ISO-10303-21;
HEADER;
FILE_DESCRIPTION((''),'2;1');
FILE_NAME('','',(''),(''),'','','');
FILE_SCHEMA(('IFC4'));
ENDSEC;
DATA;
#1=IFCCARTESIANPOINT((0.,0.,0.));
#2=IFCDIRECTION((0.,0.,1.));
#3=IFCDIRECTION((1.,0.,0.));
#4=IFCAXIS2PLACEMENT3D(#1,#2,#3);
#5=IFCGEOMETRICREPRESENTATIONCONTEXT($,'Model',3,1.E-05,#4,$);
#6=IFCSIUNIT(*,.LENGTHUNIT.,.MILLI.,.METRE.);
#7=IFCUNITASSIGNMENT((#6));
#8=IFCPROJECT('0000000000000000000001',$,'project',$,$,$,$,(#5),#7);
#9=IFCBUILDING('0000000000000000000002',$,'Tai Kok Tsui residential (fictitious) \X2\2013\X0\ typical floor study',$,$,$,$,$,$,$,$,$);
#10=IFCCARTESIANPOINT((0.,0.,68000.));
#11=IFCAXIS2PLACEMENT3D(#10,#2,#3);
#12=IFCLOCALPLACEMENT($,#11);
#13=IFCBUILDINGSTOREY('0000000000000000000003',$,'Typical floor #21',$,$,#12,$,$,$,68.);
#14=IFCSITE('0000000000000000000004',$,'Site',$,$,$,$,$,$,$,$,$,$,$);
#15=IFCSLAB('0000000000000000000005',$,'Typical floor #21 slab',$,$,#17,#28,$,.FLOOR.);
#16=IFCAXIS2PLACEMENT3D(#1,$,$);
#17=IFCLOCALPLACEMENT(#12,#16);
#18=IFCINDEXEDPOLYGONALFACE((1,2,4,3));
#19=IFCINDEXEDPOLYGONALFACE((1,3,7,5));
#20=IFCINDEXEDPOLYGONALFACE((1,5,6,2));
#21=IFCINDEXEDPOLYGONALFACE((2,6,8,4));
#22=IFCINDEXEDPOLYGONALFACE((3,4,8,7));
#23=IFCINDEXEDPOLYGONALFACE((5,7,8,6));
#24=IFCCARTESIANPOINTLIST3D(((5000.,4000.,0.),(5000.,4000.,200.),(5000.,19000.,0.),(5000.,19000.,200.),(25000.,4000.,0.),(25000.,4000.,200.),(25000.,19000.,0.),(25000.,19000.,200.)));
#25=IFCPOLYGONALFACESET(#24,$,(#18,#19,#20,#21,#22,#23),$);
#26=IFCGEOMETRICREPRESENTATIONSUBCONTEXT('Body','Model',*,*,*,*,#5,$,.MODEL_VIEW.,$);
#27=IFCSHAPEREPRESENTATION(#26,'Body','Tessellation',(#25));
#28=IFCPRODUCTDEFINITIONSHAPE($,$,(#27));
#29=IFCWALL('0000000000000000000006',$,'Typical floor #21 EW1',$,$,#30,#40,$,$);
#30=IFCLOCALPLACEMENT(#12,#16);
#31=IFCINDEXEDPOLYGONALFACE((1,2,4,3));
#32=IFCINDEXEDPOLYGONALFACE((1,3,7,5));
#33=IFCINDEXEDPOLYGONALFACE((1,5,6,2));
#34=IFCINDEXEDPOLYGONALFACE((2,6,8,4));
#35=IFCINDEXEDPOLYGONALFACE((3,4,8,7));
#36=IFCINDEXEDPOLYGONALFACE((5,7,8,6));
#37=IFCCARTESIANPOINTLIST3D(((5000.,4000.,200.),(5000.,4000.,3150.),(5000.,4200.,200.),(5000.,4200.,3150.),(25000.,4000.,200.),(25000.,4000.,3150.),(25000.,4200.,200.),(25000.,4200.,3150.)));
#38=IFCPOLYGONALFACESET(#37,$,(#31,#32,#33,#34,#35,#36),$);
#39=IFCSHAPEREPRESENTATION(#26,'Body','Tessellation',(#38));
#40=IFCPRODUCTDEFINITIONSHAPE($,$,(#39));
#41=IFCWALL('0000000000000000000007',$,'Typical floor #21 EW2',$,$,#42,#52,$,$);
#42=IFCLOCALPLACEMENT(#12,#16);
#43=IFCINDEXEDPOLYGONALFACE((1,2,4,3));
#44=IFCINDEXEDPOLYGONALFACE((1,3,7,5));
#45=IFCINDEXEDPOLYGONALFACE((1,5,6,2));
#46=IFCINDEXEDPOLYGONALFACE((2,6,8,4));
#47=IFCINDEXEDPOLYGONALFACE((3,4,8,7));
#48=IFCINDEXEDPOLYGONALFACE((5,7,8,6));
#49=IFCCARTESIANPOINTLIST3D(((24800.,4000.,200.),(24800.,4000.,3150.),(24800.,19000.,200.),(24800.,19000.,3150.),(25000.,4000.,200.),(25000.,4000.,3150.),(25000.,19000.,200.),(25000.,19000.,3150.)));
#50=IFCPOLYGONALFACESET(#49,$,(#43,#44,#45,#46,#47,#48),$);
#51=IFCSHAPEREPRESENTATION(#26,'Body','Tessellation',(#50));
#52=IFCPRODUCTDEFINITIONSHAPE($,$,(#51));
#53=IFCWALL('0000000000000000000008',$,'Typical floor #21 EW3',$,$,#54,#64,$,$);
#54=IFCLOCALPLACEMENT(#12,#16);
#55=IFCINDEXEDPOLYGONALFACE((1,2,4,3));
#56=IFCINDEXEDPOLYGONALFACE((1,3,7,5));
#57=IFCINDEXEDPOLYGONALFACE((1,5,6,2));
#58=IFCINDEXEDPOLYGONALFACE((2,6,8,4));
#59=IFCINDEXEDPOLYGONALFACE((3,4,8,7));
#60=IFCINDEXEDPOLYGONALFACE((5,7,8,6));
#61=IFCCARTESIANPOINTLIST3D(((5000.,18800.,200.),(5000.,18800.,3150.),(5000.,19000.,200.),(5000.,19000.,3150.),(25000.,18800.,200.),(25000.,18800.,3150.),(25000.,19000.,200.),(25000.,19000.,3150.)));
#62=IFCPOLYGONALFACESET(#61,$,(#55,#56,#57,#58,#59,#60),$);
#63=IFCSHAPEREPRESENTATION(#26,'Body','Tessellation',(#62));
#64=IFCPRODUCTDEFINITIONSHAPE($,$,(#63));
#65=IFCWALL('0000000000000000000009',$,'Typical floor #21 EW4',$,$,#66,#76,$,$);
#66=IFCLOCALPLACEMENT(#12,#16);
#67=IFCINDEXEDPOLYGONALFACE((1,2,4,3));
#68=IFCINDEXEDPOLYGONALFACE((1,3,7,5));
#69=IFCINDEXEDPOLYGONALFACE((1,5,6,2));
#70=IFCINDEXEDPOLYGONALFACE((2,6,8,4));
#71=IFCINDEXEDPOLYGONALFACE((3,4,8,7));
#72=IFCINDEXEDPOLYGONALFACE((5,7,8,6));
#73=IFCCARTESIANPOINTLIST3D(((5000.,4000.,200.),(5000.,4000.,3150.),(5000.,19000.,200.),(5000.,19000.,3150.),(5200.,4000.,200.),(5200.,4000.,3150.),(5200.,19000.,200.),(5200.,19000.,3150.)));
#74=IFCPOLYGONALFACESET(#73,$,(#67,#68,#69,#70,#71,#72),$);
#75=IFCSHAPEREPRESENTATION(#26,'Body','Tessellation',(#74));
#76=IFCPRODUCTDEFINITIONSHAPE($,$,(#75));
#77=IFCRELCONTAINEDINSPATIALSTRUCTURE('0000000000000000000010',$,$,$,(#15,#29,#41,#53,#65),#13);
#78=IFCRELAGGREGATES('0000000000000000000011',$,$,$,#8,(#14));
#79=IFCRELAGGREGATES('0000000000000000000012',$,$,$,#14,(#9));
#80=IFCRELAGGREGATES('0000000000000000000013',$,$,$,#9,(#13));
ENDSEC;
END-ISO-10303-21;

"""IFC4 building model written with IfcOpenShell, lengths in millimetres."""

from ifc_helpers import new_model, si_unit, frame, origin_with_axes, place, context, subcontext, project, spatial, indexed_curve, outline, extrude, element, save


model = new_model("IFC4")

# Units and contexts
model_context = context("Model", 3, precision=1e-05, world=origin_with_axes())
body_context = subcontext(model_context, "Body", "Model", "MODEL_VIEW")
ifc_project = project(units=[si_unit("LENGTHUNIT", "METRE", prefix="MILLI")], contexts=[model_context])

# Site, building, storey
site = spatial("IfcSite", under=ifc_project, Name="Site")
building = spatial("IfcBuilding", under=site, Name="Tai Kok Tsui residential (fictitious) – typical floor study")
storey_placement = place(None, frame((0.0, 0.0, 68000.0), z_axis=(0.0, 0.0, 1.0), x_axis=(1.0, 0.0, 0.0)))
storey = spatial("IfcBuildingStorey", under=building, at=storey_placement, Name="Typical floor #21", Elevation=68.0)

# Slab
slab_placement = place(storey_placement, origin_with_axes())
element("IfcSlab", 1, at=slab_placement, inside=storey, Name="Typical floor #21 slab", PredefinedType="FLOOR", context=body_context, shape_type="SweptSolid", body=[
    extrude(outline(indexed_curve([(5000.0, 4000.0), (25000.0, 4000.0), (25000.0, 19000.0), (5000.0, 19000.0)])), None, (0.0, 0.0, 1.0), 200.0),
])

# Walls
wall_1_placement = place(storey_placement, frame((5000.0, 4000.0, 200.0), z_axis=(0.0, 0.0, 1.0), x_axis=(1.0, 0.0, 0.0)))
element("IfcWall", 2, at=wall_1_placement, inside=storey, Name="Typical floor #21 EW1", context=body_context, shape_type="SweptSolid", body=[
    extrude(outline(indexed_curve([(0.0, 0.0), (0.0, 200.0), (20000.0, 200.0), (20000.0, 0.0), (0.0, 0.0)], self_intersect=False)), origin_with_axes(), (0.0, 0.0, 1.0), 2950.0),
])
wall_2_placement = place(storey_placement, frame((25000.0, 4000.0, 200.0), z_axis=(0.0, 0.0, 1.0), x_axis=(0.0, 1.0, 0.0)))
element("IfcWall", 3, at=wall_2_placement, inside=storey, Name="Typical floor #21 EW2", context=body_context, shape_type="SweptSolid", body=[
    extrude(outline(indexed_curve([(0.0, 0.0), (0.0, 200.0), (15000.0, 200.0), (15000.0, 0.0), (0.0, 0.0)], self_intersect=False)), origin_with_axes(), (0.0, 0.0, 1.0), 2950.0),
])
wall_3_placement = place(storey_placement, frame((25000.0, 19000.0, 200.0), z_axis=(0.0, 0.0, 1.0), x_axis=(-1.0, 0.0, 0.0)))
element("IfcWall", 4, at=wall_3_placement, inside=storey, Name="Typical floor #21 EW3", context=body_context, shape_type="SweptSolid", body=[
    extrude(outline(indexed_curve([(0.0, 0.0), (0.0, 200.0), (20000.0, 200.0), (20000.0, 0.0), (0.0, 0.0)], self_intersect=False)), origin_with_axes(), (0.0, 0.0, 1.0), 2950.0),
])
wall_4_placement = place(storey_placement, frame((5000.0, 19000.0, 200.0), z_axis=(0.0, 0.0, 1.0), x_axis=(0.0, -1.0, 0.0)))
element("IfcWall", 5, at=wall_4_placement, inside=storey, Name="Typical floor #21 EW4", context=body_context, shape_type="SweptSolid", body=[
    extrude(outline(indexed_curve([(0.0, 0.0), (0.0, 200.0), (15000.0, 200.0), (15000.0, 0.0), (0.0, 0.0)], self_intersect=False)), origin_with_axes(), (0.0, 0.0, 1.0), 2950.0),
])

save(model, "model.ifc")
